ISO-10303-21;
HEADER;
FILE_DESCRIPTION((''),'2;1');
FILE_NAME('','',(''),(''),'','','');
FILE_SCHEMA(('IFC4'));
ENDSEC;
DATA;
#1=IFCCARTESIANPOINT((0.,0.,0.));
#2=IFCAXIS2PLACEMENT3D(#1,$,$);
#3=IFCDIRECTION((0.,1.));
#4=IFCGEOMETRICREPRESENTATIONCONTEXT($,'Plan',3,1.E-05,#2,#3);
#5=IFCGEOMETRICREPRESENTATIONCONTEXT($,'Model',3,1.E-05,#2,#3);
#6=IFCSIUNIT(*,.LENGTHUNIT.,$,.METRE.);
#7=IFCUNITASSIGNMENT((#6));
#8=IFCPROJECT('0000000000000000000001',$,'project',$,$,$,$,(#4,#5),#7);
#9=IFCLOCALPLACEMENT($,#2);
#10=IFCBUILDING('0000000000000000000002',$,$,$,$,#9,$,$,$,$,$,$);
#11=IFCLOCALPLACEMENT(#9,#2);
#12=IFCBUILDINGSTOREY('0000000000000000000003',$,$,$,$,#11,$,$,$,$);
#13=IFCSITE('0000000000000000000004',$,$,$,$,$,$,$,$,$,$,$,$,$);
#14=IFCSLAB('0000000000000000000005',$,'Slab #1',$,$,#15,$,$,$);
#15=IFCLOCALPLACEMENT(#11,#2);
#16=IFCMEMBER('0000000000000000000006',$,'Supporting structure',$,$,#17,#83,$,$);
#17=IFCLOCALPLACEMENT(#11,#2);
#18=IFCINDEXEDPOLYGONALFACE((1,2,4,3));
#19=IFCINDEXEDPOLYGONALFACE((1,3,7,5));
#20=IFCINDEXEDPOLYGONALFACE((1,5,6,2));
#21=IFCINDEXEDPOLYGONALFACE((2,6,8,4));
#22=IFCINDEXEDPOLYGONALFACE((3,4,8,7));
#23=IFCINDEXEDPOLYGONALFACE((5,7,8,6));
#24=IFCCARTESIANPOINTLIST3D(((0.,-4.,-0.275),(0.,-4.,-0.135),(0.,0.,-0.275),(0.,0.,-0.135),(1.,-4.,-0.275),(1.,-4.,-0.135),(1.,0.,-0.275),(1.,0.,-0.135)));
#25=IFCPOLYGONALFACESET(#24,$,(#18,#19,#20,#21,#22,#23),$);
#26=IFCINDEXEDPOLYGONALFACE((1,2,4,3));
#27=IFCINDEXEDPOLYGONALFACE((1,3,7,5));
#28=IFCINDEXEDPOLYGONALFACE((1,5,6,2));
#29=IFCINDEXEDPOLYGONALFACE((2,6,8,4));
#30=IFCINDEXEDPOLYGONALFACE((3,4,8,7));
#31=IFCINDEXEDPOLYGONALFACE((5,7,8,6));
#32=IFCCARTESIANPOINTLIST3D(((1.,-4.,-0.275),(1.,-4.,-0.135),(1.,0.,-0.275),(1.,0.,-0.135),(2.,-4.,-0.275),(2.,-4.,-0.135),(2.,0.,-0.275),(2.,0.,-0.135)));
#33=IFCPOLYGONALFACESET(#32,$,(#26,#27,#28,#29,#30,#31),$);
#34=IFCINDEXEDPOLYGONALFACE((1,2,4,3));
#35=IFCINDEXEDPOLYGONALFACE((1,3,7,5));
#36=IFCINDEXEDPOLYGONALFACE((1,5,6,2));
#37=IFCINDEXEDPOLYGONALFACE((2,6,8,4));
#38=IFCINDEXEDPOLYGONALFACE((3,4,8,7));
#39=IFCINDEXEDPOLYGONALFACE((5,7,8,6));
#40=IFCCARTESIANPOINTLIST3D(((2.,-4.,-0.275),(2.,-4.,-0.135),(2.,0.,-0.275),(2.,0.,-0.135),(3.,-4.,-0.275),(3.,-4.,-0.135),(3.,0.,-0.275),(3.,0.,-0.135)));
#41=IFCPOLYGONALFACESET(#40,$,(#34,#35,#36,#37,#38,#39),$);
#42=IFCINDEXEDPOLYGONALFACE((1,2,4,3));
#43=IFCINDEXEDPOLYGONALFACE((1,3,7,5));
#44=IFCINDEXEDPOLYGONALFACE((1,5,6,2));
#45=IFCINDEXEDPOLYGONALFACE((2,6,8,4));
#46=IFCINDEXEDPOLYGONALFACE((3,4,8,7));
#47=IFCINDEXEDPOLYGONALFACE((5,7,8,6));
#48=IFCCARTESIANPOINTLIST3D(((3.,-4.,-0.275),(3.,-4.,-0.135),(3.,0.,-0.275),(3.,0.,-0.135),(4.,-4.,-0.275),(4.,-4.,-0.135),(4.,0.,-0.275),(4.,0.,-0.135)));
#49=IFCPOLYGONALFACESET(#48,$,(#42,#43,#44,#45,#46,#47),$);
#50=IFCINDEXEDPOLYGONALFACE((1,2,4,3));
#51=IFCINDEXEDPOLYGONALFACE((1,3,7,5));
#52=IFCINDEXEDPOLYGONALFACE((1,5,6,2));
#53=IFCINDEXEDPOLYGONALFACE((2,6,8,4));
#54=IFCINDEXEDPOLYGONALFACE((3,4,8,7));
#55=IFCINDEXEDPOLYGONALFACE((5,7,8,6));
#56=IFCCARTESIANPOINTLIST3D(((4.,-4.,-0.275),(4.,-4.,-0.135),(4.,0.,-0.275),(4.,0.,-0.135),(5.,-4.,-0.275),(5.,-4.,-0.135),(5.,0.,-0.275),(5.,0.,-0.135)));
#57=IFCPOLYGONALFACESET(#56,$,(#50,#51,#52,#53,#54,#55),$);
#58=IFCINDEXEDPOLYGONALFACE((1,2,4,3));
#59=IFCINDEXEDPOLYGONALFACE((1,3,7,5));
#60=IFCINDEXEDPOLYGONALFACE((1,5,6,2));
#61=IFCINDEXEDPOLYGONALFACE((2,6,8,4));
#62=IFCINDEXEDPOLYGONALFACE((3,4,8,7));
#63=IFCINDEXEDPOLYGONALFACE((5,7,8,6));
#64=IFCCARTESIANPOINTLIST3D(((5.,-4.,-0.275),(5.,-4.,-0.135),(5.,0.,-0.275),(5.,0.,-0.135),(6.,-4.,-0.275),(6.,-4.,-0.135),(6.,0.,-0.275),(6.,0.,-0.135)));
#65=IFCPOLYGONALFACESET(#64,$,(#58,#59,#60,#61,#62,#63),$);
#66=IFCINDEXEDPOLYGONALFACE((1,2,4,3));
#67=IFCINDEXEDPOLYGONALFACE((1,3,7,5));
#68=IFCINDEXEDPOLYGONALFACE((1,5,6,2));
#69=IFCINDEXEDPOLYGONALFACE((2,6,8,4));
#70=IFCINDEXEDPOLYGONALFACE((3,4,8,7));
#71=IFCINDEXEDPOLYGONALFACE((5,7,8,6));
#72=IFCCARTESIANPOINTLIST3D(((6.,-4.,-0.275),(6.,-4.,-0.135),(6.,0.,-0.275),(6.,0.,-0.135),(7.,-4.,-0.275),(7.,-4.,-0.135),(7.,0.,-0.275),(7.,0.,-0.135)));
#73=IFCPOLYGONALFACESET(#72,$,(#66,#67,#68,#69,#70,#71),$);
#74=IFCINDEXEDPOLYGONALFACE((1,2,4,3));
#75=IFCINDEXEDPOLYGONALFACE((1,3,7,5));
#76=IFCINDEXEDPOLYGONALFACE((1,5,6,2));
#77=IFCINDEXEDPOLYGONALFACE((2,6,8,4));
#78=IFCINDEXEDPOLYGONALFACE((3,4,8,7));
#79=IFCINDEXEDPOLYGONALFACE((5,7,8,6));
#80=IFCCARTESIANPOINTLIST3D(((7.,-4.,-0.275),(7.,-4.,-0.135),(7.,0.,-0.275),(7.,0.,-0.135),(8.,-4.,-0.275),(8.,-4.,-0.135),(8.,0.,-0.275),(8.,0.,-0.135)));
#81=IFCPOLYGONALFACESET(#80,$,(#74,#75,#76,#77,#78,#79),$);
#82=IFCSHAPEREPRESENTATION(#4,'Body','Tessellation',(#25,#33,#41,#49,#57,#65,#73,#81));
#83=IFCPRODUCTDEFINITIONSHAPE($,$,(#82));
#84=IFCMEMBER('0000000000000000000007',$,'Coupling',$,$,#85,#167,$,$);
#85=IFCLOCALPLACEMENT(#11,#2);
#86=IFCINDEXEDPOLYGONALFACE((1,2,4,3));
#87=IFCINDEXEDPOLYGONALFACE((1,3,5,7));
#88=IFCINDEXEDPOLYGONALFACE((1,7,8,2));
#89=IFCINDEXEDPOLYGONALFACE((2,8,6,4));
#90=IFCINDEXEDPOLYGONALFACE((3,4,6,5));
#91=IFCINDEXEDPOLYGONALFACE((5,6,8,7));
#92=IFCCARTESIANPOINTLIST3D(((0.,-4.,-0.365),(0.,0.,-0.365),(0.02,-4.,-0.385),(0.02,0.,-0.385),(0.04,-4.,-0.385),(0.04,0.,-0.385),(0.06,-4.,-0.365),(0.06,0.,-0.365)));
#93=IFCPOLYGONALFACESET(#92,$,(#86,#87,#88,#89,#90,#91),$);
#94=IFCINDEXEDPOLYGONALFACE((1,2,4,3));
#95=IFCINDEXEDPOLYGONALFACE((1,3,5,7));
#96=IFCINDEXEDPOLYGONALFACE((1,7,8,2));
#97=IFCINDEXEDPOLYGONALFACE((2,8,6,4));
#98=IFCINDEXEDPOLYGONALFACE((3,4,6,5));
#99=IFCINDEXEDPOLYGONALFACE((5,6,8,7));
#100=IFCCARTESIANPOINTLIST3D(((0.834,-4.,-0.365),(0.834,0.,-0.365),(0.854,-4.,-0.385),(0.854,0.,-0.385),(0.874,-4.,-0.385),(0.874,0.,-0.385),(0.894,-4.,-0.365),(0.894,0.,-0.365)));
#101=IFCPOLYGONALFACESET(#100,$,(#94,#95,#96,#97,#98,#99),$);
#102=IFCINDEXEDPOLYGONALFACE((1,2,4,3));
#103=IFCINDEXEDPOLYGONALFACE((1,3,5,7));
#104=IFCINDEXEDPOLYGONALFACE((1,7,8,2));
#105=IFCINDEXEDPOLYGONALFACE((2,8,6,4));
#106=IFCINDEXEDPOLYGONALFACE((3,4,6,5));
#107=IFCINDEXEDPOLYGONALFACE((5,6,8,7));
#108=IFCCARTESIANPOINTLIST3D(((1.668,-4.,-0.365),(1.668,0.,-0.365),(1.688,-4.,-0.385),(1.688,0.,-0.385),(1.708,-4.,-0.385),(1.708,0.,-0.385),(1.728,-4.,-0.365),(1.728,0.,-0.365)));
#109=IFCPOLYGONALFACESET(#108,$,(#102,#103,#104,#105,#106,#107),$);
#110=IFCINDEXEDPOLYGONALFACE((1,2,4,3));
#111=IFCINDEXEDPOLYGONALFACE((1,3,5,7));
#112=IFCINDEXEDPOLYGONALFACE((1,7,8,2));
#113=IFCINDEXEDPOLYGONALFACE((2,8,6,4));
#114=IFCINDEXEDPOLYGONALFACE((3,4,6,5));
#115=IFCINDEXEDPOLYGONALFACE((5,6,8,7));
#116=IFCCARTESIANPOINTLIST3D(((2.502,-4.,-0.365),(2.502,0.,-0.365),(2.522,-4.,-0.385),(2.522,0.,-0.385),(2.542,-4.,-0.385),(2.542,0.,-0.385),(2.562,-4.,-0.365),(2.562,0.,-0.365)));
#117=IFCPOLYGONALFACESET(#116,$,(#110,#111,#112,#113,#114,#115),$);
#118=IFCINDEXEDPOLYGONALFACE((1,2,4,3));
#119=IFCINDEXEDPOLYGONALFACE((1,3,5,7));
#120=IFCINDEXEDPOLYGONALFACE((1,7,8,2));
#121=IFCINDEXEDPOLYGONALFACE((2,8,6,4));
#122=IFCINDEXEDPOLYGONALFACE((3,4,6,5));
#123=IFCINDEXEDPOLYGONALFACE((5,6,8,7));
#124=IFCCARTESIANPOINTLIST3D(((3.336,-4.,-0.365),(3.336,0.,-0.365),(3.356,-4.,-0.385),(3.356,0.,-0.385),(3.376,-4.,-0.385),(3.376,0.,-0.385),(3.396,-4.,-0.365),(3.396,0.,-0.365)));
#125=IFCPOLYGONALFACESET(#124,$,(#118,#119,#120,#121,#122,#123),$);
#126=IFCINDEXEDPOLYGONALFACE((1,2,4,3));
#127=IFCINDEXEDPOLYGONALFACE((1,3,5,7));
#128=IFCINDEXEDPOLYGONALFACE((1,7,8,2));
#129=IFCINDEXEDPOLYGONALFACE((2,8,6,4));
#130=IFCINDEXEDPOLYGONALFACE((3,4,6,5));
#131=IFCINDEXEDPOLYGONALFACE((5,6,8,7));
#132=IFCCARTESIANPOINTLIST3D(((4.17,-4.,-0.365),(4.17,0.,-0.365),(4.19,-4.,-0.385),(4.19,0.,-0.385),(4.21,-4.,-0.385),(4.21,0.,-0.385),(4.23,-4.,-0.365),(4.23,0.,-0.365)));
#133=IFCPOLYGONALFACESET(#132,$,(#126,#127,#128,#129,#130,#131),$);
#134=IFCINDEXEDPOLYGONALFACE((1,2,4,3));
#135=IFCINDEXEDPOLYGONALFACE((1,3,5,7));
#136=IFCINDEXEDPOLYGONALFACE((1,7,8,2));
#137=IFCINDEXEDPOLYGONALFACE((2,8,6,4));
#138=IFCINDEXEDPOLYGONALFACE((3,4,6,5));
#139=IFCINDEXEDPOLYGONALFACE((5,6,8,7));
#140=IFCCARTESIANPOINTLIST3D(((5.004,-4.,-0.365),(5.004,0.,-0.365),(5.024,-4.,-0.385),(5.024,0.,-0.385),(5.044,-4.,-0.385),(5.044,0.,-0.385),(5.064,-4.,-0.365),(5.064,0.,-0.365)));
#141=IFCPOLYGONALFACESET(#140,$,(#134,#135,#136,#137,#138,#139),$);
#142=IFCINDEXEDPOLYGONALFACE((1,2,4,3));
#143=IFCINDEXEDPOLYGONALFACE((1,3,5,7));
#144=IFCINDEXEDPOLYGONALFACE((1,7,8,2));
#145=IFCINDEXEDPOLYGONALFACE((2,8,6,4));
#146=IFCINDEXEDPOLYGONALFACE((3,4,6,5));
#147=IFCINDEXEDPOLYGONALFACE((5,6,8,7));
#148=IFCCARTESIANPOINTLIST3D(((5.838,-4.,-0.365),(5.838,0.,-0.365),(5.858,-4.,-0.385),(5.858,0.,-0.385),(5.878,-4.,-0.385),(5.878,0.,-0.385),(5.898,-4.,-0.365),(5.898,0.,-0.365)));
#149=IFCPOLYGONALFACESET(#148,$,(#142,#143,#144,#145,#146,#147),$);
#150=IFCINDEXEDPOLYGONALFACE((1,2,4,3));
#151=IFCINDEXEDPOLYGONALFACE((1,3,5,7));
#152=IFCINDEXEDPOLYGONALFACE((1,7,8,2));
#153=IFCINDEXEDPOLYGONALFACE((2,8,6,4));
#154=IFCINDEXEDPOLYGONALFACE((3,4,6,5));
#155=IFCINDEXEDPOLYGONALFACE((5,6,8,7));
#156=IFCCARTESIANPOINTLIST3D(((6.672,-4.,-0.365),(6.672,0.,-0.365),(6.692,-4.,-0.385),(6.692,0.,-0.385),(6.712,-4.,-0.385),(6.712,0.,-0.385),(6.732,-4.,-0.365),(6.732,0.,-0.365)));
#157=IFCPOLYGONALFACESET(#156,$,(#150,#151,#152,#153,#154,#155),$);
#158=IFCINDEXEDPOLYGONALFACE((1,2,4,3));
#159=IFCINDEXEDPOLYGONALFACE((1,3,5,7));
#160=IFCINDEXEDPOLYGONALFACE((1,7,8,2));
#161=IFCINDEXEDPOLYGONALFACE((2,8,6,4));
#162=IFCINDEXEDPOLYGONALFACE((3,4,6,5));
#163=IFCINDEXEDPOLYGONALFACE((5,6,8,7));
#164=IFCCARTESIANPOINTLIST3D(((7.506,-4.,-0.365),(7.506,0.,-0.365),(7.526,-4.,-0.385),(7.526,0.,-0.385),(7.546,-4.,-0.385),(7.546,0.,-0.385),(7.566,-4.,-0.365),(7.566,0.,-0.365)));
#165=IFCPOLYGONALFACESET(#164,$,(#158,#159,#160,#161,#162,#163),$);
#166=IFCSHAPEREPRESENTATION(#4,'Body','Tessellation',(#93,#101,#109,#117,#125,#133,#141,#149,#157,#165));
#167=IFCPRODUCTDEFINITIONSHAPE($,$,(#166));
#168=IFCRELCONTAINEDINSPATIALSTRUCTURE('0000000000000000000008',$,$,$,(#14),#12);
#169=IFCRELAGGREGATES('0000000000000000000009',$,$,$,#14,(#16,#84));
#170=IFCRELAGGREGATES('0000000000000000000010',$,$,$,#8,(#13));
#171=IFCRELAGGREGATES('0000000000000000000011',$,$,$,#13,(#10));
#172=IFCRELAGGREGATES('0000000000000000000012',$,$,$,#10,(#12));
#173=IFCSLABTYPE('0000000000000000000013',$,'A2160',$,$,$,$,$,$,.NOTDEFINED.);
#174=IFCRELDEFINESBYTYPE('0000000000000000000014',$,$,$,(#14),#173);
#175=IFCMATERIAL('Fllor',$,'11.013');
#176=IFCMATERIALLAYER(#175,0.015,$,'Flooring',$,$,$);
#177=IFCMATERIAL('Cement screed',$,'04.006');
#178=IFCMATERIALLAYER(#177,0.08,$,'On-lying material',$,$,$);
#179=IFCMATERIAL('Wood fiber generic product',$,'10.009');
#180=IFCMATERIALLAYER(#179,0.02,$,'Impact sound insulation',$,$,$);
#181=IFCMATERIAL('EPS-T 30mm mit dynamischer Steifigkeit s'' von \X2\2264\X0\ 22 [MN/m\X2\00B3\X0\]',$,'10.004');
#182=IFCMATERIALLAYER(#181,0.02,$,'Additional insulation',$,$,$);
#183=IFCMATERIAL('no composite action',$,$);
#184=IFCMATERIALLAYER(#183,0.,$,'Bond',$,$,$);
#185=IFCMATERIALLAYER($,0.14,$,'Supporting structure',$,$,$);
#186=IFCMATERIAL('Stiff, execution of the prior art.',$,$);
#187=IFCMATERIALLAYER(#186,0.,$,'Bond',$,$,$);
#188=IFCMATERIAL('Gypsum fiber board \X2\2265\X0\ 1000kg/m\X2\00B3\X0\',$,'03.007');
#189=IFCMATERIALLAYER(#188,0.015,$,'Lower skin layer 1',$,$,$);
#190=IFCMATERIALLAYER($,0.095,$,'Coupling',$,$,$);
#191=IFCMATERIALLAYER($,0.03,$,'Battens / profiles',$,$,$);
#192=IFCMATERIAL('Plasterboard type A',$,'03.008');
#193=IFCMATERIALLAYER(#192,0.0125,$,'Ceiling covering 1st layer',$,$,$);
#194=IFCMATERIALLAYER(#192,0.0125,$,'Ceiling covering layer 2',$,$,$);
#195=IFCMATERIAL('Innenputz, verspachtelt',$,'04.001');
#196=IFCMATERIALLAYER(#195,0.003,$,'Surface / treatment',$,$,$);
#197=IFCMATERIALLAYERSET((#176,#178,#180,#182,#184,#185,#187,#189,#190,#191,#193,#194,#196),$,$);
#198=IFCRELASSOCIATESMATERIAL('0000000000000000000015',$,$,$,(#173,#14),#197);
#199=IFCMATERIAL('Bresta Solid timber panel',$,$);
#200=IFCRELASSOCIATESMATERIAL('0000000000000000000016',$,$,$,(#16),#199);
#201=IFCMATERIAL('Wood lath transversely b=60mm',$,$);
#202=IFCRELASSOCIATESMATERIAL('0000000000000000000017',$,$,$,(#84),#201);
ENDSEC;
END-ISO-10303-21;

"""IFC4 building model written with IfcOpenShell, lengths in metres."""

from ifc_helpers import new_model, si_unit, direction, frame, frame_2d, origin, place, context, project, spatial, polyline, rectangle, outline, extrude, material, layer, layer_set, type_object, element, aggregate, save


model = new_model("IFC4")

# Units and contexts
plan_context = context("Plan", 3, precision=1e-05, world=origin(), true_north=direction((0.0, 1.0)))
model_context = context("Model", 3, precision=1e-05, world=origin(), true_north=direction((0.0, 1.0)))
ifc_project = project(units=[si_unit("LENGTHUNIT", "METRE")], contexts=[plan_context, model_context])

# Site, building, storey
site = spatial("IfcSite", under=ifc_project)
building_placement = place(None, origin())
building = spatial("IfcBuilding", under=site, at=building_placement)
storey_placement = place(building_placement, origin())
storey = spatial("IfcBuildingStorey", under=building, at=storey_placement)

# Slab, members
ifc_material_1 = material(Name="Fllor", Category="11.013")
ifc_layer_1 = layer(ifc_material_1, 0.015, Name="Flooring")
ifc_material_2 = material(Name="Cement screed", Category="04.006")
ifc_layer_2 = layer(ifc_material_2, 0.08, Name="On-lying material")
ifc_material_3 = material(Name="Wood fiber generic product", Category="10.009")
ifc_layer_3 = layer(ifc_material_3, 0.02, Name="Impact sound insulation")
ifc_material_4 = material(Name="EPS-T 30mm mit dynamischer Steifigkeit s' von ≤ 22 [MN/m³]", Category="10.004")
ifc_layer_4 = layer(ifc_material_4, 0.02, Name="Additional insulation")
ifc_material_5 = material(Name="no composite action")
ifc_layer_5 = layer(ifc_material_5, 0.0, Name="Bond")
ifc_layer_6 = layer(None, 0.14, Name="Supporting structure")
ifc_material_6 = material(Name="Stiff, execution of the prior art.")
ifc_layer_7 = layer(ifc_material_6, 0.0, Name="Bond")
ifc_material_7 = material(Name="Gypsum fiber board ≥ 1000kg/m³", Category="03.007")
ifc_layer_8 = layer(ifc_material_7, 0.015, Name="Lower skin layer 1")
ifc_layer_9 = layer(None, 0.095, Name="Coupling")
ifc_layer_10 = layer(None, 0.03, Name="Battens / profiles")
ifc_material_8 = material(Name="Plasterboard type A", Category="03.008")
ifc_layer_11 = layer(ifc_material_8, 0.0125, Name="Ceiling covering 1st layer")
ifc_layer_12 = layer(ifc_material_8, 0.0125, Name="Ceiling covering layer 2")
ifc_material_9 = material(Name="Innenputz, verspachtelt", Category="04.001")
ifc_layer_13 = layer(ifc_material_9, 0.003, Name="Surface / treatment")
ifc_layer_set = layer_set([ifc_layer_1, ifc_layer_2, ifc_layer_3, ifc_layer_4, ifc_layer_5, ifc_layer_6, ifc_layer_7, ifc_layer_8, ifc_layer_9, ifc_layer_10, ifc_layer_11, ifc_layer_12, ifc_layer_13])
slab_type = type_object("IfcSlabType", Name="A2160", PredefinedType="NOTDEFINED", material=ifc_layer_set)
slab_placement = place(None, frame((0.0, 0.0, 0.0), z_axis=(0.0, 0.0, -1.0), x_axis=(1.0, 0.0, 0.0)))
slab = element("IfcSlab", 1, at=slab_placement, inside=storey, type_object=slab_type, material=ifc_layer_set, Name="Slab #1")
ifc_material_10 = material(Name="Bresta Solid timber panel")
member_1_placement = place(slab_placement, origin())
member_1 = element("IfcMember", 2, at=member_1_placement, material=ifc_material_10, Name="Supporting structure", context=plan_context, shape_type="SweptSolid", body=[
    extrude(rectangle(XDim=1.0, YDim=0.14, at=frame_2d((0.5, 0.07), x_axis=(1.0, 0.0))), frame((0.0, 4.0, 0.135), z_axis=(0.0, -1.0, 0.0), x_axis=(1.0, 0.0, 0.0)), (0.0, 0.0, 1.0), 4.0),
    extrude(rectangle(XDim=1.0, YDim=0.14, at=frame_2d((0.5, 0.07), x_axis=(1.0, 0.0))), frame((1.0, 4.0, 0.135), z_axis=(0.0, -1.0, 0.0), x_axis=(1.0, 0.0, 0.0)), (0.0, 0.0, 1.0), 4.0),
    extrude(rectangle(XDim=1.0, YDim=0.14, at=frame_2d((0.5, 0.07), x_axis=(1.0, 0.0))), frame((2.0, 4.0, 0.135), z_axis=(0.0, -1.0, 0.0), x_axis=(1.0, 0.0, 0.0)), (0.0, 0.0, 1.0), 4.0),
    extrude(rectangle(XDim=1.0, YDim=0.14, at=frame_2d((0.5, 0.07), x_axis=(1.0, 0.0))), frame((3.0, 4.0, 0.135), z_axis=(0.0, -1.0, 0.0), x_axis=(1.0, 0.0, 0.0)), (0.0, 0.0, 1.0), 4.0),
    extrude(rectangle(XDim=1.0, YDim=0.14, at=frame_2d((0.5, 0.07), x_axis=(1.0, 0.0))), frame((4.0, 4.0, 0.135), z_axis=(0.0, -1.0, 0.0), x_axis=(1.0, 0.0, 0.0)), (0.0, 0.0, 1.0), 4.0),
    extrude(rectangle(XDim=1.0, YDim=0.14, at=frame_2d((0.5, 0.07), x_axis=(1.0, 0.0))), frame((5.0, 4.0, 0.135), z_axis=(0.0, -1.0, 0.0), x_axis=(1.0, 0.0, 0.0)), (0.0, 0.0, 1.0), 4.0),
    extrude(rectangle(XDim=1.0, YDim=0.14, at=frame_2d((0.5, 0.07), x_axis=(1.0, 0.0))), frame((6.0, 4.0, 0.135), z_axis=(0.0, -1.0, 0.0), x_axis=(1.0, 0.0, 0.0)), (0.0, 0.0, 1.0), 4.0),
    extrude(rectangle(XDim=1.0, YDim=0.14, at=frame_2d((0.5, 0.07), x_axis=(1.0, 0.0))), frame((7.0, 4.0, 0.135), z_axis=(0.0, -1.0, 0.0), x_axis=(1.0, 0.0, 0.0)), (0.0, 0.0, 1.0), 4.0),
])
ifc_material_11 = material(Name="Wood lath transversely b=60mm")
member_2_placement = place(slab_placement, origin())
member_2 = element("IfcMember", 3, at=member_2_placement, material=ifc_material_11, Name="Coupling", context=plan_context, shape_type="SweptSolid", body=[
    extrude(outline(polyline([(0.0, 0.0), (0.06, 0.0), (0.04, 0.02), (0.02, 0.02), (0.0, 0.0)])), frame((0.0, 4.0, 0.365), z_axis=(0.0, -1.0, 0.0), x_axis=(1.0, 0.0, 0.0)), (0.0, 0.0, 1.0), 4.0),
    extrude(outline(polyline([(0.0, 0.0), (0.06, 0.0), (0.04, 0.02), (0.02, 0.02), (0.0, 0.0)])), frame((0.834, 4.0, 0.365), z_axis=(0.0, -1.0, 0.0), x_axis=(1.0, 0.0, 0.0)), (0.0, 0.0, 1.0), 4.0),
    extrude(outline(polyline([(0.0, 0.0), (0.06, 0.0), (0.04, 0.02), (0.02, 0.02), (0.0, 0.0)])), frame((1.668, 4.0, 0.365), z_axis=(0.0, -1.0, 0.0), x_axis=(1.0, 0.0, 0.0)), (0.0, 0.0, 1.0), 4.0),
    extrude(outline(polyline([(0.0, 0.0), (0.06, 0.0), (0.04, 0.02), (0.02, 0.02), (0.0, 0.0)])), frame((2.502, 4.0, 0.365), z_axis=(0.0, -1.0, 0.0), x_axis=(1.0, 0.0, 0.0)), (0.0, 0.0, 1.0), 4.0),
    extrude(outline(polyline([(0.0, 0.0), (0.06, 0.0), (0.04, 0.02), (0.02, 0.02), (0.0, 0.0)])), frame((3.336, 4.0, 0.365), z_axis=(0.0, -1.0, 0.0), x_axis=(1.0, 0.0, 0.0)), (0.0, 0.0, 1.0), 4.0),
    extrude(outline(polyline([(0.0, 0.0), (0.06, 0.0), (0.04, 0.02), (0.02, 0.02), (0.0, 0.0)])), frame((4.17, 4.0, 0.365), z_axis=(0.0, -1.0, 0.0), x_axis=(1.0, 0.0, 0.0)), (0.0, 0.0, 1.0), 4.0),
    extrude(outline(polyline([(0.0, 0.0), (0.06, 0.0), (0.04, 0.02), (0.02, 0.02), (0.0, 0.0)])), frame((5.004, 4.0, 0.365), z_axis=(0.0, -1.0, 0.0), x_axis=(1.0, 0.0, 0.0)), (0.0, 0.0, 1.0), 4.0),
    extrude(outline(polyline([(0.0, 0.0), (0.06, 0.0), (0.04, 0.02), (0.02, 0.02), (0.0, 0.0)])), frame((5.838, 4.0, 0.365), z_axis=(0.0, -1.0, 0.0), x_axis=(1.0, 0.0, 0.0)), (0.0, 0.0, 1.0), 4.0),
    extrude(outline(polyline([(0.0, 0.0), (0.06, 0.0), (0.04, 0.02), (0.02, 0.02), (0.0, 0.0)])), frame((6.672, 4.0, 0.365), z_axis=(0.0, -1.0, 0.0), x_axis=(1.0, 0.0, 0.0)), (0.0, 0.0, 1.0), 4.0),
    extrude(outline(polyline([(0.0, 0.0), (0.06, 0.0), (0.04, 0.02), (0.02, 0.02), (0.0, 0.0)])), frame((7.506, 4.0, 0.365), z_axis=(0.0, -1.0, 0.0), x_axis=(1.0, 0.0, 0.0)), (0.0, 0.0, 1.0), 4.0),
])
aggregate(slab, [member_1, member_2])

save(model, "model.ifc")
